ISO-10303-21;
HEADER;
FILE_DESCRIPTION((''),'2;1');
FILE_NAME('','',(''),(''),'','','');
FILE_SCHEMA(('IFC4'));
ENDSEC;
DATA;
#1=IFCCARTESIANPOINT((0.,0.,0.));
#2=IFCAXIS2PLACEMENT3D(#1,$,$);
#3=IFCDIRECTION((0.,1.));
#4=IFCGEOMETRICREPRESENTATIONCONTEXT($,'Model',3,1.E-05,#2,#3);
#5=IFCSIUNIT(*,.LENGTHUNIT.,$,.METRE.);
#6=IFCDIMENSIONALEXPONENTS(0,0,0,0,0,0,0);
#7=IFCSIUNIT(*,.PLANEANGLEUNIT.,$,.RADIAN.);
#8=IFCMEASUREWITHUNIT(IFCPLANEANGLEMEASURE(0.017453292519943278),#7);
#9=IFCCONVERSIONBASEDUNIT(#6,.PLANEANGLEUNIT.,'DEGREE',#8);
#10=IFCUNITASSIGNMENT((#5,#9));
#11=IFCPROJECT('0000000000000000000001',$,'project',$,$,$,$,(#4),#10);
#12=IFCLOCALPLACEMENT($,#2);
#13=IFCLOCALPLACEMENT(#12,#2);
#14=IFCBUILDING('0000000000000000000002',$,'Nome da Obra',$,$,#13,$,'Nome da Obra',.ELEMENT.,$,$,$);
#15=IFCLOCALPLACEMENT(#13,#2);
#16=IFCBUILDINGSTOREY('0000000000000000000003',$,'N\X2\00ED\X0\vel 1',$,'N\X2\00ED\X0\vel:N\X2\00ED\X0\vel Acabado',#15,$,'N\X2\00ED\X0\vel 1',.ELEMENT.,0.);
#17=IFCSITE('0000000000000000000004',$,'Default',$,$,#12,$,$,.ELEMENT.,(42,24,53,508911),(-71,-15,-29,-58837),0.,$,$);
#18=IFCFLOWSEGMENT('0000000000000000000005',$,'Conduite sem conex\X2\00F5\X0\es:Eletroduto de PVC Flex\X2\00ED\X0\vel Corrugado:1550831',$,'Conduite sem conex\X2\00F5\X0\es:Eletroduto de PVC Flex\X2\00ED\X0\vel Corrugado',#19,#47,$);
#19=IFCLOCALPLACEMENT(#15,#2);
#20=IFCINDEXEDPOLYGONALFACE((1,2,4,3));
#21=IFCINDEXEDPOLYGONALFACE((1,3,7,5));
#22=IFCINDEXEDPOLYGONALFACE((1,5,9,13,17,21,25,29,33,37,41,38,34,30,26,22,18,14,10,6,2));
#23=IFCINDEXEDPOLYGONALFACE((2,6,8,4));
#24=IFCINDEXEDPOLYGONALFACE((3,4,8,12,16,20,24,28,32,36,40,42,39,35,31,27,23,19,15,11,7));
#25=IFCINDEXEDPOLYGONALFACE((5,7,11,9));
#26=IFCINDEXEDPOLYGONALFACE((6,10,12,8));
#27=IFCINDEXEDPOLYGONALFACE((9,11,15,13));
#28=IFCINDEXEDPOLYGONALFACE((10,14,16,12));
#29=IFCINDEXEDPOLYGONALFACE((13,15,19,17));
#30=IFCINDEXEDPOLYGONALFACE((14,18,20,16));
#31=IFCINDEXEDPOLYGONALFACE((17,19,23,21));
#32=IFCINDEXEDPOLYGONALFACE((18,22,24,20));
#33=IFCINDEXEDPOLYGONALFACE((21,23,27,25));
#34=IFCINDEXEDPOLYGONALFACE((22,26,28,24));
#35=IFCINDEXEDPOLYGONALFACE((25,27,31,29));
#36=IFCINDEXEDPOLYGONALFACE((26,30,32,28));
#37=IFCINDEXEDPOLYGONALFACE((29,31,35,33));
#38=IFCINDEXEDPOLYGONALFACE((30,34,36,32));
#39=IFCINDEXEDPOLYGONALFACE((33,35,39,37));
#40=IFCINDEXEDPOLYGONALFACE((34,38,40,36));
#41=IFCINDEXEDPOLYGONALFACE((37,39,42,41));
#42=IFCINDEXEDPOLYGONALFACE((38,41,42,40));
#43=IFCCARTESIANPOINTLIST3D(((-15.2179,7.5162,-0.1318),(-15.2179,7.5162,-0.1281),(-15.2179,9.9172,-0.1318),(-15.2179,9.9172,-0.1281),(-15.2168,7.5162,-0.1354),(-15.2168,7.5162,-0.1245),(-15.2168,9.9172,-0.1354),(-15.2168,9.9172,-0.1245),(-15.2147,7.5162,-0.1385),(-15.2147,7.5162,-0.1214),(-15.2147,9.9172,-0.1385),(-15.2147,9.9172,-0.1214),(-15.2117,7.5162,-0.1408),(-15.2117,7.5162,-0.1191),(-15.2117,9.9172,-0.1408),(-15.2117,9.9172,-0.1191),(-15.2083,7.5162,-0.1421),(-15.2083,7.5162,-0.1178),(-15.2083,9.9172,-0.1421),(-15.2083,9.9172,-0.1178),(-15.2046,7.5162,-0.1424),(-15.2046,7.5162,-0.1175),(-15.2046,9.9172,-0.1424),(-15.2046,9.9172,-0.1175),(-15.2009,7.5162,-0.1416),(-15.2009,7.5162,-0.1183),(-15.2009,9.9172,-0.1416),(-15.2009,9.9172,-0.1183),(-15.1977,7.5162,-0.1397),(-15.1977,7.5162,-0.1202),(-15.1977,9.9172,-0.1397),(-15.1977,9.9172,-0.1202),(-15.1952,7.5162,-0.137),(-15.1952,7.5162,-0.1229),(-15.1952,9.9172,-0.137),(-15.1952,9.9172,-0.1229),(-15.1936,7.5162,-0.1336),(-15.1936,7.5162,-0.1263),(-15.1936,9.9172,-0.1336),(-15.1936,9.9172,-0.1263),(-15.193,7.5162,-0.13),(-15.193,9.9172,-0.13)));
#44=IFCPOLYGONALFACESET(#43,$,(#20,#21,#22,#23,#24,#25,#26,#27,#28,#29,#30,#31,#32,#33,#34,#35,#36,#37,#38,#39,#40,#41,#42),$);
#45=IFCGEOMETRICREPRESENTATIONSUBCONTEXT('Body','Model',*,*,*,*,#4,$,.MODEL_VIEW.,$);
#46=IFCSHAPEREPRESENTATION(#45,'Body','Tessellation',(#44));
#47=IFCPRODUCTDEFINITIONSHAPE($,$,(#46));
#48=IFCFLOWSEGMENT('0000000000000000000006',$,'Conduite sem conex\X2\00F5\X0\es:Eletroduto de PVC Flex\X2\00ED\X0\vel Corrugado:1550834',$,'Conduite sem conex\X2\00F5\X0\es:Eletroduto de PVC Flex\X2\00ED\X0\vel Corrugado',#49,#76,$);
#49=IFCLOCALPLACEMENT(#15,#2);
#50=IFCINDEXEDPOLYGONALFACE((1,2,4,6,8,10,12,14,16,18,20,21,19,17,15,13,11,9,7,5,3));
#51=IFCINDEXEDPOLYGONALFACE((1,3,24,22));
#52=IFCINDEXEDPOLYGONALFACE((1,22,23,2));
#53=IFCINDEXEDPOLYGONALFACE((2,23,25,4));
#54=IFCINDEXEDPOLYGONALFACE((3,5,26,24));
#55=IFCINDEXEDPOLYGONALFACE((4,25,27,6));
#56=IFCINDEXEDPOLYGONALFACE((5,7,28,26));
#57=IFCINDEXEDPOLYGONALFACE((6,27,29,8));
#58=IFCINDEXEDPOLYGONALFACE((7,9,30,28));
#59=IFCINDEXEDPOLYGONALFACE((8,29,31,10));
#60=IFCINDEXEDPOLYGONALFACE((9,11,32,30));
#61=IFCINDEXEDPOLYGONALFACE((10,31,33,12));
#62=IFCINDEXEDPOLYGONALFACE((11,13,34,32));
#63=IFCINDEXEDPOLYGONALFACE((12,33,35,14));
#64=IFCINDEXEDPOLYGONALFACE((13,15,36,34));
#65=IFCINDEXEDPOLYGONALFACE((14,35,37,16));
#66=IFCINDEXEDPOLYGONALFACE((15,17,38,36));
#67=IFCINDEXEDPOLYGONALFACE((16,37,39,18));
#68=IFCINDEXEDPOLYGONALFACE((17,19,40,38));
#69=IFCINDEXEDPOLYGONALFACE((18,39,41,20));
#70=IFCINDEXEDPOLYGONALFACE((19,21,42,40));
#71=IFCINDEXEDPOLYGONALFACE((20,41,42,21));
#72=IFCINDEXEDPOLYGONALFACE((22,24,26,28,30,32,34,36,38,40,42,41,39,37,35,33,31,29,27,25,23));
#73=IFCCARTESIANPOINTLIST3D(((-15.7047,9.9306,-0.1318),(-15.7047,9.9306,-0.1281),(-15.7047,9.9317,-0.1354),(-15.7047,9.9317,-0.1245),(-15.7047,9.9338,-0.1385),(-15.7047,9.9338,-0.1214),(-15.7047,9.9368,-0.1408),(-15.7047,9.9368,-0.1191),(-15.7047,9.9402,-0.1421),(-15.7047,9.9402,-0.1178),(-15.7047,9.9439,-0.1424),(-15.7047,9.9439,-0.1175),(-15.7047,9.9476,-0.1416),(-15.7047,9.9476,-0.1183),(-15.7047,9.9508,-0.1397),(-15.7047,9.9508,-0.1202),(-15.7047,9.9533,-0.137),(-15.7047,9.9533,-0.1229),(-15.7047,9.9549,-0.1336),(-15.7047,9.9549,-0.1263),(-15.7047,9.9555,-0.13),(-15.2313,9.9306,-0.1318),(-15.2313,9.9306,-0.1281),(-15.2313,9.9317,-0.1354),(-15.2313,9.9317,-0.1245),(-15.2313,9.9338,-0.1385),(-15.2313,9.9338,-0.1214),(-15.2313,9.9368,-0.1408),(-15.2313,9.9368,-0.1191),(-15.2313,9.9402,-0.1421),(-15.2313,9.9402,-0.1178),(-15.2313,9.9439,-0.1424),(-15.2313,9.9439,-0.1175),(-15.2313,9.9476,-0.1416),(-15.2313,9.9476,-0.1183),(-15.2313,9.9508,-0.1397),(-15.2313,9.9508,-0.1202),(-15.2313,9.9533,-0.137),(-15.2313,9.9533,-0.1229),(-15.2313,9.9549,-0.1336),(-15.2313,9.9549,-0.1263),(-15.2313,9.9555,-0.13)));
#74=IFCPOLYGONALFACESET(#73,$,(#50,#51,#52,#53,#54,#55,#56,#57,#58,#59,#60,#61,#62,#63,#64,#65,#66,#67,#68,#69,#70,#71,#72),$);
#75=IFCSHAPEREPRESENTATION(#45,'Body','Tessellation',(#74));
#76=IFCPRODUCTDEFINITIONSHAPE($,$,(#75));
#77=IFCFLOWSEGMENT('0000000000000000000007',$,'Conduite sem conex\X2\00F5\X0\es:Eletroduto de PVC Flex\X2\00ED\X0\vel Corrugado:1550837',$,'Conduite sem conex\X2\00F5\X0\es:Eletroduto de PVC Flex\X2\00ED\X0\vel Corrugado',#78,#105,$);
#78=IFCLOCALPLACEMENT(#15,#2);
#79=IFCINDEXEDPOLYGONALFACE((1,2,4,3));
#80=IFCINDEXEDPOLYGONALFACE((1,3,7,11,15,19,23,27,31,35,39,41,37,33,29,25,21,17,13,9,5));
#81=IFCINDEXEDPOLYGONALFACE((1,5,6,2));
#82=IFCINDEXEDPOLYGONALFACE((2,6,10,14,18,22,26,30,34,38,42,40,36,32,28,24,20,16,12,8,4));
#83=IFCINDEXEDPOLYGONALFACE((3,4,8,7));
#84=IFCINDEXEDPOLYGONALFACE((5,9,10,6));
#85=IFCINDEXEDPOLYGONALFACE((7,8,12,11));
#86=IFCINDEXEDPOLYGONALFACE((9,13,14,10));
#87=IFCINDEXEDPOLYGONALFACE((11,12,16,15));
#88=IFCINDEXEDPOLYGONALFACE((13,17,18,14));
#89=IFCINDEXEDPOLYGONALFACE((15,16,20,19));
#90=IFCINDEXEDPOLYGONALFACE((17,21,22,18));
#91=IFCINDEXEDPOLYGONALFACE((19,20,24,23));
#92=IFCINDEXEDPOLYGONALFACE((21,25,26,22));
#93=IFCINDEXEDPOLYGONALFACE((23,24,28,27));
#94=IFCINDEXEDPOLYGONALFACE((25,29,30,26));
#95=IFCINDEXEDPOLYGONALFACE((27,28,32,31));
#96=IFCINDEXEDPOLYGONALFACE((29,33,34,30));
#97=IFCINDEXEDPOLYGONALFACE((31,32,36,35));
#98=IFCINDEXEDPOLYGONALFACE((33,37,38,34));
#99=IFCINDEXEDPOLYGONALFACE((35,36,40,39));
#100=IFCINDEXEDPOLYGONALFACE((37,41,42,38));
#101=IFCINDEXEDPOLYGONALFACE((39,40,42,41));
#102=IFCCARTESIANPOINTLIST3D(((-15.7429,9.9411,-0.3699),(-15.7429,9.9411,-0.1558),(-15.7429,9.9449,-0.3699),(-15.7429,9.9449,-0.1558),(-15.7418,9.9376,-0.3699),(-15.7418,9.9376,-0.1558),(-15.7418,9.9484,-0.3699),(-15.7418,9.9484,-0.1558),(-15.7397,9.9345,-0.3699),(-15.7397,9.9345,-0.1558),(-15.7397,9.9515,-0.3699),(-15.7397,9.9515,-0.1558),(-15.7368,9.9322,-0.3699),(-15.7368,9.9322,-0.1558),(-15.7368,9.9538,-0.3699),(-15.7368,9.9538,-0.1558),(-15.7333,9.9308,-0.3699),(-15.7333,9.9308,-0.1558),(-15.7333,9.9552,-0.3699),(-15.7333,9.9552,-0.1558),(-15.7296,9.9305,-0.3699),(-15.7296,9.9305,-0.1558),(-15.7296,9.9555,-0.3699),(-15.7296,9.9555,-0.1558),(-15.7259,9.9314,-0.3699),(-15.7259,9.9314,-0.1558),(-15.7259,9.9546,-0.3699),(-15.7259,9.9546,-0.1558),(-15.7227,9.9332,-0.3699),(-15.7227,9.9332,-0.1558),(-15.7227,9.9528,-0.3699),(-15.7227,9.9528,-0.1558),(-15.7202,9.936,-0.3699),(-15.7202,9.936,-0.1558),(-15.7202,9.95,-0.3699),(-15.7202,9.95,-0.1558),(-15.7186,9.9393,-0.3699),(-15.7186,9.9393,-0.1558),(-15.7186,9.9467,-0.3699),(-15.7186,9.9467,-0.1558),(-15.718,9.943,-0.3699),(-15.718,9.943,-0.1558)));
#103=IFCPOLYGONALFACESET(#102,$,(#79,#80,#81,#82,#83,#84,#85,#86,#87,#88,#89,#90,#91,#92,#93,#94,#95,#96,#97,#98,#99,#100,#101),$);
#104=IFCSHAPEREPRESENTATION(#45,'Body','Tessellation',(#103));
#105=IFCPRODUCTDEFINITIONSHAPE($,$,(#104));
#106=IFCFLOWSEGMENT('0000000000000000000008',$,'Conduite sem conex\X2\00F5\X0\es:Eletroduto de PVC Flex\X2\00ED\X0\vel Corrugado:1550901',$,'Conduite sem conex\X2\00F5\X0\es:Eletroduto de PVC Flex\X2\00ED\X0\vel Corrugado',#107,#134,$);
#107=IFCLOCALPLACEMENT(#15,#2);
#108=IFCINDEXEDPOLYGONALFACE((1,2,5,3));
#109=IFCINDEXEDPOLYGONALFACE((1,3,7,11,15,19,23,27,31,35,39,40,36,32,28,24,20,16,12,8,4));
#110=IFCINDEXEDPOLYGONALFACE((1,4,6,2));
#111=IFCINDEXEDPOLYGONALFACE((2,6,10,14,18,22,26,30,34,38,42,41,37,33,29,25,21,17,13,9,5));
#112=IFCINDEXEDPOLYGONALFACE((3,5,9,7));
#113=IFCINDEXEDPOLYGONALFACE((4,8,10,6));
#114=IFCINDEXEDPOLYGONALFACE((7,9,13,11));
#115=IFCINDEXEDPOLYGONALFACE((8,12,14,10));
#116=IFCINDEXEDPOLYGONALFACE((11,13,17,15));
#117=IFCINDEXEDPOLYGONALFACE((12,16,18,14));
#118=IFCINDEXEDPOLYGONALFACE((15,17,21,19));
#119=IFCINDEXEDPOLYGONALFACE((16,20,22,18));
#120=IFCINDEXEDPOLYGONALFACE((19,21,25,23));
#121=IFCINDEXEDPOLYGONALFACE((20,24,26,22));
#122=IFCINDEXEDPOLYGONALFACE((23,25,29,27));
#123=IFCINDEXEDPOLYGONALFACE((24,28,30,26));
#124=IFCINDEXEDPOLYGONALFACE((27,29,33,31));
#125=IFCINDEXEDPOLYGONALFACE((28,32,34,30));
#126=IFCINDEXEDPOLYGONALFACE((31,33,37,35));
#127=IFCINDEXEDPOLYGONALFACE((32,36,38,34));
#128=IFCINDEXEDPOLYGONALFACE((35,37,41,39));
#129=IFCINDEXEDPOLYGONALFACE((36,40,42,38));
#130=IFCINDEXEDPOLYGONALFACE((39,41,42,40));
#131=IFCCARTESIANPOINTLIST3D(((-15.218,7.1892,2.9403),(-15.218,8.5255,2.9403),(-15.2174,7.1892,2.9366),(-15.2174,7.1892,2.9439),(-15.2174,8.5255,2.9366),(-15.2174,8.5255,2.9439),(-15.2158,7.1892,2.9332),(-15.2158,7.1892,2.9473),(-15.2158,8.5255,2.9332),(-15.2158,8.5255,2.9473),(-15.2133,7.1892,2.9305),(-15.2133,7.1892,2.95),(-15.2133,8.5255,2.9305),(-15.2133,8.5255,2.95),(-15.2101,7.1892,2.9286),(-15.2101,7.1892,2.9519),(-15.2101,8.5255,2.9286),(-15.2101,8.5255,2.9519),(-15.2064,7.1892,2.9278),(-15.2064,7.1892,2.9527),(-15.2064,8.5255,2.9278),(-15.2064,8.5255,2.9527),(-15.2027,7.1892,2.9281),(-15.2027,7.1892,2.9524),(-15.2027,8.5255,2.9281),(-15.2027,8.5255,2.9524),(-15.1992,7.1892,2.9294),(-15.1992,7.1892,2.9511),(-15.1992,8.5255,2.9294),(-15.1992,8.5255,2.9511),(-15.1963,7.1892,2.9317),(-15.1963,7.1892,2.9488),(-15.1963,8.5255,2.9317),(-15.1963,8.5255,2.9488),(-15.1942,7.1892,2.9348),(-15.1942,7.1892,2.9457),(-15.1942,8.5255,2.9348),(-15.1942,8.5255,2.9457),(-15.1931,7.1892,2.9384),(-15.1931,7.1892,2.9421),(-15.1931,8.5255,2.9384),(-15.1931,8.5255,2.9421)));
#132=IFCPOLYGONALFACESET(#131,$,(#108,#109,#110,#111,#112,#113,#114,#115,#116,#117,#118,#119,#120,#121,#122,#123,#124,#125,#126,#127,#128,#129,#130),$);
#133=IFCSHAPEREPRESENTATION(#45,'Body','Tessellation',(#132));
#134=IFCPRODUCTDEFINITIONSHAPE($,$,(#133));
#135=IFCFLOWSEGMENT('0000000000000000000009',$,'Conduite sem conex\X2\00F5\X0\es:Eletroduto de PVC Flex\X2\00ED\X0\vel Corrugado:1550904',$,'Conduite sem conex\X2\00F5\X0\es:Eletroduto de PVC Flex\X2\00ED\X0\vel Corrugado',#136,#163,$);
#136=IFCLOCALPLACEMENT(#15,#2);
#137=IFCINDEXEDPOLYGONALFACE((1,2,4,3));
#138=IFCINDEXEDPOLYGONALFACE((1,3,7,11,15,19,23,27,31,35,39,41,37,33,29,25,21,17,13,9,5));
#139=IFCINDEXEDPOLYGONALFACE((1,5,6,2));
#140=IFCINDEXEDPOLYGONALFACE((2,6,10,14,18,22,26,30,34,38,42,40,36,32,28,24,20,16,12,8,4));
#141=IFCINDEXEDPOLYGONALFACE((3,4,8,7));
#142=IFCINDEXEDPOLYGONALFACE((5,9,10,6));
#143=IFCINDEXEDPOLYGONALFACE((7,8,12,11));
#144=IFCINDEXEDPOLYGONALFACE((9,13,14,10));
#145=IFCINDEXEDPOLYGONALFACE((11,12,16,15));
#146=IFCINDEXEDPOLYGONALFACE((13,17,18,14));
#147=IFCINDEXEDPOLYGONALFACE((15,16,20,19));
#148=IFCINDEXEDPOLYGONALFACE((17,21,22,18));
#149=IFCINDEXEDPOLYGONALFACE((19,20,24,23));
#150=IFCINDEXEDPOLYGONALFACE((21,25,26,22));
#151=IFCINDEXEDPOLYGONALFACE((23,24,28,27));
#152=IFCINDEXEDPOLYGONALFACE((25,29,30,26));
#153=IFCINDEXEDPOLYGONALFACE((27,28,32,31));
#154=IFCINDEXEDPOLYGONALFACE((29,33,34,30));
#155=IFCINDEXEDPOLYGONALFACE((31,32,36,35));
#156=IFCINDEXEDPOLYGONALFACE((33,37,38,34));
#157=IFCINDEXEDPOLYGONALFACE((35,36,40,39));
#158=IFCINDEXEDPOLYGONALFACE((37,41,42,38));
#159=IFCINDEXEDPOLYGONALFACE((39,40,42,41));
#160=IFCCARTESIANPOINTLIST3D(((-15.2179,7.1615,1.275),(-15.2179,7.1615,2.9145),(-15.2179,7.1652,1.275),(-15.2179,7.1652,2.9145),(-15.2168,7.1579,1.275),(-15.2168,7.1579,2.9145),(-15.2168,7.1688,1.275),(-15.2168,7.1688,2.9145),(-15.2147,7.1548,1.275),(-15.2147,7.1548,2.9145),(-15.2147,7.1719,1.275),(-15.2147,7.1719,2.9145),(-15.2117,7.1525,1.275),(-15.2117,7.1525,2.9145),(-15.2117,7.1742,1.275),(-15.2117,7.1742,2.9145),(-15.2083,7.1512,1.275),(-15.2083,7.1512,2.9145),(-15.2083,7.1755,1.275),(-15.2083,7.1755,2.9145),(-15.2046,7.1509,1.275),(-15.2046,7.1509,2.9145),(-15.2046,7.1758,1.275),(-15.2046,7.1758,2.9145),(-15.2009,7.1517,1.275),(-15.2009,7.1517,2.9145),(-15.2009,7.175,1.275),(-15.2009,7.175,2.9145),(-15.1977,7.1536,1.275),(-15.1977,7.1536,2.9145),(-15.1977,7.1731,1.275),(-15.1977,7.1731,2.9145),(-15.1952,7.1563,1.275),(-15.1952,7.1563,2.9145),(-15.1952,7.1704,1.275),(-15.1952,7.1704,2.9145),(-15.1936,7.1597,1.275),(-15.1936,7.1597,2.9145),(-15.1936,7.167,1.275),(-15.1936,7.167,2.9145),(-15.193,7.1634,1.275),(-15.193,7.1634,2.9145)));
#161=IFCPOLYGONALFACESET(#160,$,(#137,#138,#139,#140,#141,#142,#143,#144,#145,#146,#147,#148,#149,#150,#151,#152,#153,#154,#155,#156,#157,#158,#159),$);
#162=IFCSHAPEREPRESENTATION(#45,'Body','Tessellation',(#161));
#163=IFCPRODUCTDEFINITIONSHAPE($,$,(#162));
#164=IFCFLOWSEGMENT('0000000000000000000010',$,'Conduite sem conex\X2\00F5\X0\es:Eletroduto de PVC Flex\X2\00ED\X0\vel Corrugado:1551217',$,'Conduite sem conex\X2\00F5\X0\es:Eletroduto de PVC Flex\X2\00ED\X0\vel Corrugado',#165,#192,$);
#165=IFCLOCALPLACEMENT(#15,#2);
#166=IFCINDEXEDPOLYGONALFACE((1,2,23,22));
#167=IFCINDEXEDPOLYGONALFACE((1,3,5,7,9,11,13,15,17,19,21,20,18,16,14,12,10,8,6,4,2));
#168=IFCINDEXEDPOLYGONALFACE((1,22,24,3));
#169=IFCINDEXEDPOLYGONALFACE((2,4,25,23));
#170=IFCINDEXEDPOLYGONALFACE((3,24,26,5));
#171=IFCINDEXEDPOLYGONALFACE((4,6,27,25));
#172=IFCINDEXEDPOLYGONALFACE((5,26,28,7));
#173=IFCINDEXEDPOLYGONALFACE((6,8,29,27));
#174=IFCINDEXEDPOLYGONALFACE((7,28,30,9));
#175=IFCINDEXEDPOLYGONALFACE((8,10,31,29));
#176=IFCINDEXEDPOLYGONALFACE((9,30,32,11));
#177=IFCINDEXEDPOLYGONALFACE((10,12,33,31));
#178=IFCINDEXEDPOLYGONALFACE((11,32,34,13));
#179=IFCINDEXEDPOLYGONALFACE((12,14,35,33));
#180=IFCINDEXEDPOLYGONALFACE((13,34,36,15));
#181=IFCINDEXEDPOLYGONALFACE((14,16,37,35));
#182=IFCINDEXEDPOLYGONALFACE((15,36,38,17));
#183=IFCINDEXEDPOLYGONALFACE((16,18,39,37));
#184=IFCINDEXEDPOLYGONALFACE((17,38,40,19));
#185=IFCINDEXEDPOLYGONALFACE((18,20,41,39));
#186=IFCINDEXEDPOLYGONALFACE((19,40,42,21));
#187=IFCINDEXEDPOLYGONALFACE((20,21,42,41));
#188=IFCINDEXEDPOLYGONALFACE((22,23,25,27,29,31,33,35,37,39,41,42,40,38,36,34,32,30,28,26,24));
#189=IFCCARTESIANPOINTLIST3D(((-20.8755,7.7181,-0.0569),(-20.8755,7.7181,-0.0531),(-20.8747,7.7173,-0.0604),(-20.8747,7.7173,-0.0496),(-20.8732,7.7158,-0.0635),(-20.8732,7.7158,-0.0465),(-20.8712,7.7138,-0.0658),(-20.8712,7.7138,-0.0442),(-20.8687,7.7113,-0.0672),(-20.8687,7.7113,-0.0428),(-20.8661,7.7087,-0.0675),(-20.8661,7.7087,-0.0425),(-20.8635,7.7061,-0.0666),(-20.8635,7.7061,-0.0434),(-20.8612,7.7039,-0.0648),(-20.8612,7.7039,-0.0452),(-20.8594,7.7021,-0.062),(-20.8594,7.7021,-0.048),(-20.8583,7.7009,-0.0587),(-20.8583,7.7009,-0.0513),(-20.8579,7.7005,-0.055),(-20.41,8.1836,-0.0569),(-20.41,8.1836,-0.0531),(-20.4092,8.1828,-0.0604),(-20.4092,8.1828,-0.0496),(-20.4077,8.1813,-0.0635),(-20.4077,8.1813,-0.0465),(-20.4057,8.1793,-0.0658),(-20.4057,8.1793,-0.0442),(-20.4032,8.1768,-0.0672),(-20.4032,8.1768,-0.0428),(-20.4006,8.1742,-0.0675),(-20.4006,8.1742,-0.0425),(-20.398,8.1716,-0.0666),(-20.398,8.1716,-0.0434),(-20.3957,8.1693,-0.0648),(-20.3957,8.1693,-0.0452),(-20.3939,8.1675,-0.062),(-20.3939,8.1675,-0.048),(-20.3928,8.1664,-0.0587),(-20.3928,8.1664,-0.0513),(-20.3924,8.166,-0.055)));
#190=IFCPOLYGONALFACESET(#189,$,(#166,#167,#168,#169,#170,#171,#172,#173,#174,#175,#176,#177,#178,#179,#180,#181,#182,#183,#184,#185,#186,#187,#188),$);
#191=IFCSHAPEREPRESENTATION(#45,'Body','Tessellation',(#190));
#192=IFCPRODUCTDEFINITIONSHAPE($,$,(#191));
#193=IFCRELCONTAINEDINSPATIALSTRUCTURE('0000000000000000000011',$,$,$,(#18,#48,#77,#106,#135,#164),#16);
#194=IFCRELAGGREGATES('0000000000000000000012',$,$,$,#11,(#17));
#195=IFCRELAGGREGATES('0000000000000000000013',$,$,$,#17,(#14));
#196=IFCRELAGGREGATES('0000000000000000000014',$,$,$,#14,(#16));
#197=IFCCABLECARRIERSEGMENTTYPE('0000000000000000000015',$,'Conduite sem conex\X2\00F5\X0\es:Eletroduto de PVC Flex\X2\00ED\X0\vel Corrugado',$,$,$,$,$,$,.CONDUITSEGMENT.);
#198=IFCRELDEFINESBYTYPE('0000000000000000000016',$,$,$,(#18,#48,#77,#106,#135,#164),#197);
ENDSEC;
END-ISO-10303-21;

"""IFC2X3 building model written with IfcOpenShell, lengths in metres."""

from ifc_helpers import new_model, entity, si_unit, converted_unit, direction, frame, frame_2d, origin, origin_2d_with_axis, place, context, subcontext, project, spatial, circle, extrude, type_object, element, save


model = new_model("IFC2X3")

# Units and contexts
model_context = context("Model", 3, precision=1e-05, world=origin(), true_north=direction((0.0, 1.0)))
body_context = subcontext(model_context, "Body", "Model", "MODEL_VIEW")
ifc_project = project(units=[si_unit("LENGTHUNIT", "METRE"), converted_unit("PLANEANGLEUNIT", "DEGREE", entity("IfcPlaneAngleMeasure", 0.017453292519943278), si_unit("PLANEANGLEUNIT", "RADIAN"), dimensions=[0, 0, 0, 0, 0, 0, 0])], contexts=[model_context])

# Site, building, storey
site_placement = place(None, origin())
site = spatial("IfcSite", under=ifc_project, at=site_placement, Name="Default", CompositionType="ELEMENT", RefLatitude=(42, 24, 53, 508911), RefLongitude=(-71, -15, -29, -58837), RefElevation=0.0)
building_placement = place(site_placement, origin())
building = spatial("IfcBuilding", under=site, at=building_placement, Name="Nome da Obra", LongName="Nome da Obra", CompositionType="ELEMENT")
storey_placement = place(building_placement, origin())
storey = spatial("IfcBuildingStorey", under=building, at=storey_placement, Name="Nível 1", ObjectType="Nível:Nível Acabado", LongName="Nível 1", CompositionType="ELEMENT", Elevation=0.0)

# Flow segments
cable_carrier_segment_type = type_object("IfcCableCarrierSegmentType", Name="Conduite sem conexões:Eletroduto de PVC Flexível Corrugado", PredefinedType="CONDUITSEGMENT")
flow_segment_1_placement = place(storey_placement, origin())
element("IfcFlowSegment", 1, at=flow_segment_1_placement, inside=storey, type_object=cable_carrier_segment_type, Name="Conduite sem conexões:Eletroduto de PVC Flexível Corrugado:1550831", ObjectType="Conduite sem conexões:Eletroduto de PVC Flexível Corrugado", context=body_context, shape_type="SweptSolid", body=[
    extrude(circle(Radius=0.0125, at=frame_2d((0.0, 0.0), x_axis=(1.0, 0.0))), frame((-15.2055, 7.5162, -0.13), z_axis=(0.0, 1.0, 0.0), x_axis=(1.0, 0.0, 0.0)), (0.0, 0.0, 1.0), 2.401),
])
flow_segment_2_placement = place(storey_placement, origin())
element("IfcFlowSegment", 2, at=flow_segment_2_placement, inside=storey, type_object=cable_carrier_segment_type, Name="Conduite sem conexões:Eletroduto de PVC Flexível Corrugado:1550834", ObjectType="Conduite sem conexões:Eletroduto de PVC Flexível Corrugado", context=body_context, shape_type="SweptSolid", body=[
    extrude(circle(Radius=0.0125, at=frame_2d((0.0, 0.0), x_axis=(1.0, 0.0))), frame((-15.7047, 9.943, -0.13), z_axis=(1.0, 0.0, 0.0), x_axis=(0.0, 1.0, 0.0)), (0.0, 0.0, 1.0), 0.4734),
])
flow_segment_3_placement = place(storey_placement, origin())
element("IfcFlowSegment", 3, at=flow_segment_3_placement, inside=storey, type_object=cable_carrier_segment_type, Name="Conduite sem conexões:Eletroduto de PVC Flexível Corrugado:1550837", ObjectType="Conduite sem conexões:Eletroduto de PVC Flexível Corrugado", context=body_context, shape_type="SweptSolid", body=[
    extrude(circle(Radius=0.0125, at=origin_2d_with_axis()), frame((-15.7305, 9.943, -0.3699)), (0.0, 0.0, 1.0), 0.2142),
])
flow_segment_4_placement = place(storey_placement, origin())
element("IfcFlowSegment", 4, at=flow_segment_4_placement, inside=storey, type_object=cable_carrier_segment_type, Name="Conduite sem conexões:Eletroduto de PVC Flexível Corrugado:1550901", ObjectType="Conduite sem conexões:Eletroduto de PVC Flexível Corrugado", context=body_context, shape_type="SweptSolid", body=[
    extrude(circle(Radius=0.0125, at=frame_2d((0.0, 0.0), x_axis=(1.0, 0.0))), frame((-15.2055, 7.1892, 2.9403), z_axis=(0.0, 1.0, 0.0), x_axis=(-1.0, 0.0, 0.0)), (0.0, 0.0, 1.0), 1.3363),
])
flow_segment_5_placement = place(storey_placement, origin())
element("IfcFlowSegment", 5, at=flow_segment_5_placement, inside=storey, type_object=cable_carrier_segment_type, Name="Conduite sem conexões:Eletroduto de PVC Flexível Corrugado:1550904", ObjectType="Conduite sem conexões:Eletroduto de PVC Flexível Corrugado", context=body_context, shape_type="SweptSolid", body=[
    extrude(circle(Radius=0.0125, at=frame_2d((0.0, 0.0), x_axis=(1.0, 0.0))), frame((-15.2055, 7.1634, 1.275)), (0.0, 0.0, 1.0), 1.6394),
])
flow_segment_6_placement = place(storey_placement, origin())
element("IfcFlowSegment", 6, at=flow_segment_6_placement, inside=storey, type_object=cable_carrier_segment_type, Name="Conduite sem conexões:Eletroduto de PVC Flexível Corrugado:1551217", ObjectType="Conduite sem conexões:Eletroduto de PVC Flexível Corrugado", context=body_context, shape_type="SweptSolid", body=[
    extrude(circle(Radius=0.0125, at=frame_2d((0.0, 0.0), x_axis=(1.0, 0.0))), frame((-20.8667, 7.7094, -0.055), z_axis=(0.707107, 0.707107, 0.0), x_axis=(0.707107, -0.707107, 0.0)), (0.0, 0.0, 1.0), 0.6583),
])

save(model, "model.ifc")
